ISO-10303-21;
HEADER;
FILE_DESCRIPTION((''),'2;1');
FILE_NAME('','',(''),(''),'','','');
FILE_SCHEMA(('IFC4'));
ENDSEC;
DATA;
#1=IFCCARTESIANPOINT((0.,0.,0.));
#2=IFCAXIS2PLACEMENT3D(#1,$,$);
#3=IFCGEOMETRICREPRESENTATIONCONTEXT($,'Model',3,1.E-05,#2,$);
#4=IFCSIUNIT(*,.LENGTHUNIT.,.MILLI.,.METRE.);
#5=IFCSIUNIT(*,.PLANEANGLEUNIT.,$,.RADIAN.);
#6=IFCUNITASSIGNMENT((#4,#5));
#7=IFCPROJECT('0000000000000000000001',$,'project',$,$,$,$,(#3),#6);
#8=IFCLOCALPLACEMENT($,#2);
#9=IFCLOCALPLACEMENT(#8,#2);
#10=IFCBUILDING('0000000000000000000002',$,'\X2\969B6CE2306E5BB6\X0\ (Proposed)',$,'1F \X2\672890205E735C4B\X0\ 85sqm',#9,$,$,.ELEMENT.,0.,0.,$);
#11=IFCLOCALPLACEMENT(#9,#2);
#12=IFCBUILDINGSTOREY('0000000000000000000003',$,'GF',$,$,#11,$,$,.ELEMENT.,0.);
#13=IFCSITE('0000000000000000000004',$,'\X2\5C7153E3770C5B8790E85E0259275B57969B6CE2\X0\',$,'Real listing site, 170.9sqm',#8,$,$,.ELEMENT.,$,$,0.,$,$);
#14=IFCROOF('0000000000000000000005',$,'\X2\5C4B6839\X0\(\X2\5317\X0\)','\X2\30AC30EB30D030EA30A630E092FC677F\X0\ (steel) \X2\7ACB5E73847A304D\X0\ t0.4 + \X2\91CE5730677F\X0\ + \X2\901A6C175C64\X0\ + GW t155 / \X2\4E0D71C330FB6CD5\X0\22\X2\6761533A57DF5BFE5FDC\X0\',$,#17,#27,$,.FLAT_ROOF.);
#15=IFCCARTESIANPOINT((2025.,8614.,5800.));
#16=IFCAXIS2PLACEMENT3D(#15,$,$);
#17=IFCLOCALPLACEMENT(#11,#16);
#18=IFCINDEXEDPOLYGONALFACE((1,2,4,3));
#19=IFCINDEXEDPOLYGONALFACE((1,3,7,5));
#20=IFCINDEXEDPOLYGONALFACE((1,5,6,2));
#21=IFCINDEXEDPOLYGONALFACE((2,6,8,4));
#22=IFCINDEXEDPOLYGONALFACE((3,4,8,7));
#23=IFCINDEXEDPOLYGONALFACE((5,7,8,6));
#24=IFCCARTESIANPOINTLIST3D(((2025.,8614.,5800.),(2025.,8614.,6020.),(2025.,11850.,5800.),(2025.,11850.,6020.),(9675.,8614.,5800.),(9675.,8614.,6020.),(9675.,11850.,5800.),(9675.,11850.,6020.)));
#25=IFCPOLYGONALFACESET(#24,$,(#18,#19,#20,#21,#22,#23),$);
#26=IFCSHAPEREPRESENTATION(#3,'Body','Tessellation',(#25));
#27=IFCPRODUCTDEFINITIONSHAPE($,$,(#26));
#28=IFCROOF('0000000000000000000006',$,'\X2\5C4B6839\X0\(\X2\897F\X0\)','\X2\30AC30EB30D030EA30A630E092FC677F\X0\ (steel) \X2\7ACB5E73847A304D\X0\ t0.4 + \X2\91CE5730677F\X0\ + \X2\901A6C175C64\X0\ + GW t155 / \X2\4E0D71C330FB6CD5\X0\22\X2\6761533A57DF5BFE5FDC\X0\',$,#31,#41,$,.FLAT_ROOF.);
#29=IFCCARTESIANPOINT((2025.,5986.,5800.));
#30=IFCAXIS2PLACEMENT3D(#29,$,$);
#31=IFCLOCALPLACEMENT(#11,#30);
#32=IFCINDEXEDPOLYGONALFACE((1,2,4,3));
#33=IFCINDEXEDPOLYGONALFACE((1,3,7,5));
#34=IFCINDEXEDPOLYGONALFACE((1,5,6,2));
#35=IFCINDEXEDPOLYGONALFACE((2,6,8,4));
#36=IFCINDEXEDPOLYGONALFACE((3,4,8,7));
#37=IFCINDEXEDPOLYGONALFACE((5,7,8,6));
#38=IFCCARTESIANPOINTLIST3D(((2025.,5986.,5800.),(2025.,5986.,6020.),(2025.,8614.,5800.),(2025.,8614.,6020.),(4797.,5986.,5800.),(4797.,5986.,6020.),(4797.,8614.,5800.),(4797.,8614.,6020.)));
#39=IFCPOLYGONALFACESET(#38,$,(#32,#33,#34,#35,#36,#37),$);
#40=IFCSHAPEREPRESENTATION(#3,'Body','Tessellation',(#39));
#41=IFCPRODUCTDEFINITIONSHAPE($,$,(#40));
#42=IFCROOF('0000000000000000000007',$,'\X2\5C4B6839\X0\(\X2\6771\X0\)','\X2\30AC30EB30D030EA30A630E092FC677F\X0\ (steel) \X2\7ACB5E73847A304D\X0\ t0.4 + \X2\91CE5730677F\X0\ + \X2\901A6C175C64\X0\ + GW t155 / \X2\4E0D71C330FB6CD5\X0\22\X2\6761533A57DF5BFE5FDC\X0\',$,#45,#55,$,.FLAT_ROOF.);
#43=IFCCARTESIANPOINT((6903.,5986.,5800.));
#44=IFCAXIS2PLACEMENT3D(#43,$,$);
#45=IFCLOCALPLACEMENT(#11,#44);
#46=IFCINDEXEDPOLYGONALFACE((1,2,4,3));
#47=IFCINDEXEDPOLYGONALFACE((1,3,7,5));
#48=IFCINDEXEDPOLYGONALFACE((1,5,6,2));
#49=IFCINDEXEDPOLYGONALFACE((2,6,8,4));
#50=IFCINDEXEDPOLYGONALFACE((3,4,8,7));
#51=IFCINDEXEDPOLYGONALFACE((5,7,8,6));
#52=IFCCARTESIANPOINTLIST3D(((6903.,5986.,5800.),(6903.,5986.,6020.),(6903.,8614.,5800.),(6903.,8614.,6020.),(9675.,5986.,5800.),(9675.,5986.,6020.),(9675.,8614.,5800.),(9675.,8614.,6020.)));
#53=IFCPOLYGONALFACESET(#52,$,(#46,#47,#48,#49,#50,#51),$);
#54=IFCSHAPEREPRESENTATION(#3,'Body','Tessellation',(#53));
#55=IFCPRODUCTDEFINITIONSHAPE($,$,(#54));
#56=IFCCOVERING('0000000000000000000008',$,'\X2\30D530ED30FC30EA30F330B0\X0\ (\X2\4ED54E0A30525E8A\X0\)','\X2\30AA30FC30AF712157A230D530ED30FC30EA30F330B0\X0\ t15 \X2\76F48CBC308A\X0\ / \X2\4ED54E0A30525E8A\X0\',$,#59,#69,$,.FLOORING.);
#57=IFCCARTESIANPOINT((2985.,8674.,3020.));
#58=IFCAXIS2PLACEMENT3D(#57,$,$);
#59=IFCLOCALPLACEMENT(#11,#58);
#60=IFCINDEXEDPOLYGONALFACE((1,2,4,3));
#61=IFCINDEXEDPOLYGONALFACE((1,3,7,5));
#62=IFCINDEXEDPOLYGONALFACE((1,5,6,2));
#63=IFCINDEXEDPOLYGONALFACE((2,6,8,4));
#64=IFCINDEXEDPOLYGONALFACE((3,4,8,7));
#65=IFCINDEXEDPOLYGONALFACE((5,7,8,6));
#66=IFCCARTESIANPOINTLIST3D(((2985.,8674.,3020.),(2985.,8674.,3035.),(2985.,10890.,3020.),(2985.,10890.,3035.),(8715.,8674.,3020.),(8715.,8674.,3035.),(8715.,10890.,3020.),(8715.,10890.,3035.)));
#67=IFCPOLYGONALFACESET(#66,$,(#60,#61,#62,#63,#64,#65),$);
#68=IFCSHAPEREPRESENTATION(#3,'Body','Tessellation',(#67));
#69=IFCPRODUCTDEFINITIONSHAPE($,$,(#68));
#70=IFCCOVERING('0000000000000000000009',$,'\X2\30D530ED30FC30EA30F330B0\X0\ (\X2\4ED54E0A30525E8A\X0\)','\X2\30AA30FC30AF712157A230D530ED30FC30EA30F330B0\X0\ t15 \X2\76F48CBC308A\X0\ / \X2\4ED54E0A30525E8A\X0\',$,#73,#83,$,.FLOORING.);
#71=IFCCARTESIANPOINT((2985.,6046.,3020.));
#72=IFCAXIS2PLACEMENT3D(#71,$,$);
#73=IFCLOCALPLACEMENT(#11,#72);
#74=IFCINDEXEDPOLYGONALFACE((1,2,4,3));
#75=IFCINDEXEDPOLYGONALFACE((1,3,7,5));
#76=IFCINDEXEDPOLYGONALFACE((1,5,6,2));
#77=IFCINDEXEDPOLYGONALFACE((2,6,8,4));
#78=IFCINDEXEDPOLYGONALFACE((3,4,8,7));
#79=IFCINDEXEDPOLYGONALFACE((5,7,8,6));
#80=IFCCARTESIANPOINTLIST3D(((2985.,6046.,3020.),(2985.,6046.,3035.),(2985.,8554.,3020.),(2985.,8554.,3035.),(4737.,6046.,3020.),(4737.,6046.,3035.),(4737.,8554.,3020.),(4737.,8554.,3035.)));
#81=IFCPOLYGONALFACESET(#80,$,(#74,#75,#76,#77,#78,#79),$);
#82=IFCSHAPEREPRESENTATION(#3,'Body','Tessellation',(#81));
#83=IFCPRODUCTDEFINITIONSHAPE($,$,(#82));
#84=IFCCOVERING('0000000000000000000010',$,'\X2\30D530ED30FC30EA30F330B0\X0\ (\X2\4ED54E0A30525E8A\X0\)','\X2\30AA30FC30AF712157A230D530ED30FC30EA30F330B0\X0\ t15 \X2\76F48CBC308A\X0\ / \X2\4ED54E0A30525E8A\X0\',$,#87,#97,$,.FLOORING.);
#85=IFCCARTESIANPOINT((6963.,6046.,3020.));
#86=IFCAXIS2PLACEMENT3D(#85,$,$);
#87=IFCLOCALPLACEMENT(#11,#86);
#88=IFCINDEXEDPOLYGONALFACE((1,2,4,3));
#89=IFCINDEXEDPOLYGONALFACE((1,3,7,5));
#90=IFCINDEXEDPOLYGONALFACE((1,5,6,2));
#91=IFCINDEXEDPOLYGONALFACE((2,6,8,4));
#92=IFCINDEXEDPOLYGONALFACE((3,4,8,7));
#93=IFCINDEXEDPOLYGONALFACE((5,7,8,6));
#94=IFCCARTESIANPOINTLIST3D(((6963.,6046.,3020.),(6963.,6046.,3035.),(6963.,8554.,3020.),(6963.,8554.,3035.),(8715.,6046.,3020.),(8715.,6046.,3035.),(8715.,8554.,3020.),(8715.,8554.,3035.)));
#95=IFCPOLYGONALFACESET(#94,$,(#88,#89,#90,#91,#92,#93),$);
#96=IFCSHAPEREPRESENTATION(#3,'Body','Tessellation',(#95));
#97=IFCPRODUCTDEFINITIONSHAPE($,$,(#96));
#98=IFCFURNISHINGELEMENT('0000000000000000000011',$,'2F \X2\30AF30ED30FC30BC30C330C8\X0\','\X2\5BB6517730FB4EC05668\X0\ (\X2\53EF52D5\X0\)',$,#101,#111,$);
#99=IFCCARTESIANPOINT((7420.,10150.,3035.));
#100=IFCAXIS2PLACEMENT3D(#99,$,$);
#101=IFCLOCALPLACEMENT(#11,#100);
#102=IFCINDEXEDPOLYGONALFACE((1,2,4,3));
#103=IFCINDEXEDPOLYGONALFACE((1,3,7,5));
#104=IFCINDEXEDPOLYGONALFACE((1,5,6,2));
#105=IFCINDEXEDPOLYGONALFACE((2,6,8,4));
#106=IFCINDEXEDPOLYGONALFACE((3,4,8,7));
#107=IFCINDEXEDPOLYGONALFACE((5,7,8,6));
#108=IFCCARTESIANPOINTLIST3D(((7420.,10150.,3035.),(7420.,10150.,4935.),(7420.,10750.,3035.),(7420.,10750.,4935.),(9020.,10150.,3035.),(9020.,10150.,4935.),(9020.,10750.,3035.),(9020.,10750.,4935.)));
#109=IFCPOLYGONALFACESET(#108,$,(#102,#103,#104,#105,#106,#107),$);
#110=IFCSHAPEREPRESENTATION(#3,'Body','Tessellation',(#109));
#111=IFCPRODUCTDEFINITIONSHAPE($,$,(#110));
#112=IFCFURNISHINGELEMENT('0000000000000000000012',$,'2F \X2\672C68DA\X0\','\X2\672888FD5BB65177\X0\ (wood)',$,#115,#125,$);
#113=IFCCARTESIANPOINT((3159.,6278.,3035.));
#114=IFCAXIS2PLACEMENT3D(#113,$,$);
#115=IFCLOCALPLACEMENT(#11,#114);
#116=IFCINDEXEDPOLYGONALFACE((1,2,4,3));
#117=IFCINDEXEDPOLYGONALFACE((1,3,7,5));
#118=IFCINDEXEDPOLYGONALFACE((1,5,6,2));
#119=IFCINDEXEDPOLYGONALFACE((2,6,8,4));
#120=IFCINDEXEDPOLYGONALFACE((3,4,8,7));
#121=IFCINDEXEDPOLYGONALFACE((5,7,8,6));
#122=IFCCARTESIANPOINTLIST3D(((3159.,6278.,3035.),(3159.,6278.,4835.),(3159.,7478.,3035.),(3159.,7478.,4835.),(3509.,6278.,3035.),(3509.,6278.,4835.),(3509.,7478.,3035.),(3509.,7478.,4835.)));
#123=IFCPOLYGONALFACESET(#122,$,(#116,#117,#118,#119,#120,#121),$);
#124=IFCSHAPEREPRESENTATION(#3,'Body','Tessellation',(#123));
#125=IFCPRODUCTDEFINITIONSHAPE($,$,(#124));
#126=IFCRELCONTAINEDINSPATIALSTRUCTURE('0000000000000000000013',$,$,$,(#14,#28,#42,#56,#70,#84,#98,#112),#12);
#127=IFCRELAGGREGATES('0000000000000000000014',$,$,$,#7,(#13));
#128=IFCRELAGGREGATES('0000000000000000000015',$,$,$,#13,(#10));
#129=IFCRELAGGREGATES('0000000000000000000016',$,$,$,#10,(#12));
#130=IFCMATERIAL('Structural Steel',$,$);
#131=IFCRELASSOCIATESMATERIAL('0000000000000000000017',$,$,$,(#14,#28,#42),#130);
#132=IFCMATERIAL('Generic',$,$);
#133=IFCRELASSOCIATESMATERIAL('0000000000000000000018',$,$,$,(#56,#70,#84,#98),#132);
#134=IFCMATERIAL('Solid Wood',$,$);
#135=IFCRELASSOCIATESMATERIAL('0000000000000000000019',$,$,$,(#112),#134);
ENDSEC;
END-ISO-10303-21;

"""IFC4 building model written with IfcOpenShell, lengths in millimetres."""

from ifc_helpers import new_model, si_unit, frame, frame_2d, origin, place, context, project, spatial, rectangle, extrude, material, element, save


model = new_model("IFC4")

# Units and contexts
model_context = context("Model", 3, precision=1e-05, world=origin())
ifc_project = project(units=[si_unit("LENGTHUNIT", "METRE", prefix="MILLI"), si_unit("PLANEANGLEUNIT", "RADIAN")], contexts=[model_context])

# Site, building, storey
site_placement = place(None, origin())
site = spatial("IfcSite", under=ifc_project, at=site_placement, Name="山口県宇部市大字際波", ObjectType="Real listing site, 170.9sqm", CompositionType="ELEMENT", RefElevation=0.0)
building_placement = place(site_placement, origin())
building = spatial("IfcBuilding", under=site, at=building_placement, Name="際波の家 (Proposed)", ObjectType="1F 木造平屋 85sqm", CompositionType="ELEMENT", ElevationOfRefHeight=0.0, ElevationOfTerrain=0.0)
storey_placement = place(building_placement, origin())
storey = spatial("IfcBuildingStorey", under=building, at=storey_placement, Name="GF", CompositionType="ELEMENT", Elevation=0.0)

# Shared definitions
ifc_material_1 = material(Name="Solid Wood")

# Shared definitions
ifc_material_2 = material(Name="Generic")

# Roofs
ifc_material_3 = material(Name="Structural Steel")
for number, where, name in (
    (1, (2025.0, 8614.0, 5800.0), "屋根(北)"),
):
    element("IfcRoof", number, at=place(storey_placement, frame(where)), inside=storey, material=ifc_material_3, Name=name, Description="ガルバリウム鋼板 (steel) 立平葺き t0.4 + 野地板 + 通気層 + GW t155 / 不燃・法22条区域対応", PredefinedType="FLAT_ROOF", context=model_context, shape_type="SweptSolid", body=[
        extrude(rectangle(XDim=7650.0, YDim=3236.0, at=frame_2d((3825.0, 1618.0))), frame((2025.0, 8614.0, 5800.0)), (0.0, 0.0, 1.0), 220.0),
    ])
roof_1_placement = place(storey_placement, frame((2025.0, 5986.0, 5800.0)))
element("IfcRoof", 2, at=roof_1_placement, inside=storey, material=ifc_material_3, Name="屋根(西)", Description="ガルバリウム鋼板 (steel) 立平葺き t0.4 + 野地板 + 通気層 + GW t155 / 不燃・法22条区域対応", PredefinedType="FLAT_ROOF", context=model_context, shape_type="SweptSolid", body=[
    extrude(rectangle(XDim=2772.0, YDim=2628.0, at=frame_2d((1386.0, 1314.0))), frame((2025.0, 5986.0, 5800.0)), (0.0, 0.0, 1.0), 220.0),
])
roof_2_placement = place(storey_placement, frame((6903.0, 5986.0, 5800.0)))
element("IfcRoof", 3, at=roof_2_placement, inside=storey, material=ifc_material_3, Name="屋根(東)", Description="ガルバリウム鋼板 (steel) 立平葺き t0.4 + 野地板 + 通気層 + GW t155 / 不燃・法22条区域対応", PredefinedType="FLAT_ROOF", context=model_context, shape_type="SweptSolid", body=[
    extrude(rectangle(XDim=2772.0, YDim=2628.0, at=frame_2d((1386.0, 1314.0))), frame((6903.0, 5986.0, 5800.0)), (0.0, 0.0, 1.0), 220.0),
])

# Coverings
covering_1_placement = place(storey_placement, frame((2985.0, 8674.0, 3020.0)))
element("IfcCovering", 4, at=covering_1_placement, inside=storey, material=ifc_material_2, Name="フローリング (仕上げ床)", Description="オーク無垢フローリング t15 直貼り / 仕上げ床", PredefinedType="FLOORING", context=model_context, shape_type="SweptSolid", body=[
    extrude(rectangle(XDim=5730.0, YDim=2216.0, at=frame_2d((2865.0, 1108.0))), frame((2985.0, 8674.0, 3020.0)), (0.0, 0.0, 1.0), 15.0),
])
covering_2_placement = place(storey_placement, frame((2985.0, 6046.0, 3020.0)))
element("IfcCovering", 5, at=covering_2_placement, inside=storey, material=ifc_material_2, Name="フローリング (仕上げ床)", Description="オーク無垢フローリング t15 直貼り / 仕上げ床", PredefinedType="FLOORING", context=model_context, shape_type="SweptSolid", body=[
    extrude(rectangle(XDim=1752.0, YDim=2508.0, at=frame_2d((876.0, 1254.0))), frame((2985.0, 6046.0, 3020.0)), (0.0, 0.0, 1.0), 15.0),
])
covering_3_placement = place(storey_placement, frame((6963.0, 6046.0, 3020.0)))
element("IfcCovering", 6, at=covering_3_placement, inside=storey, material=ifc_material_2, Name="フローリング (仕上げ床)", Description="オーク無垢フローリング t15 直貼り / 仕上げ床", PredefinedType="FLOORING", context=model_context, shape_type="SweptSolid", body=[
    extrude(rectangle(XDim=1752.0, YDim=2508.0, at=frame_2d((876.0, 1254.0))), frame((6963.0, 6046.0, 3020.0)), (0.0, 0.0, 1.0), 15.0),
])

# Furnishing elements
furnishing_1_placement = place(storey_placement, frame((7420.0, 10150.0, 3035.0)))
element("IfcFurnishingElement", 7, at=furnishing_1_placement, inside=storey, material=ifc_material_2, Name="2F クローゼット", Description="家具・什器 (可動)", context=model_context, shape_type="SweptSolid", body=[
    extrude(rectangle(XDim=1600.0, YDim=600.0, at=frame_2d((800.0, 300.0))), frame((7420.0, 10150.0, 3035.0)), (0.0, 0.0, 1.0), 1900.0),
])
furnishing_2_placement = place(storey_placement, frame((3159.0, 6278.0, 3035.0)))
element("IfcFurnishingElement", 8, at=furnishing_2_placement, inside=storey, material=ifc_material_1, Name="2F 本棚", Description="木製家具 (wood)", context=model_context, shape_type="SweptSolid", body=[
    extrude(rectangle(XDim=350.0, YDim=1200.0, at=frame_2d((175.0, 600.0))), frame((3159.0, 6278.0, 3035.0)), (0.0, 0.0, 1.0), 1800.0),
])

save(model, "model.ifc")
